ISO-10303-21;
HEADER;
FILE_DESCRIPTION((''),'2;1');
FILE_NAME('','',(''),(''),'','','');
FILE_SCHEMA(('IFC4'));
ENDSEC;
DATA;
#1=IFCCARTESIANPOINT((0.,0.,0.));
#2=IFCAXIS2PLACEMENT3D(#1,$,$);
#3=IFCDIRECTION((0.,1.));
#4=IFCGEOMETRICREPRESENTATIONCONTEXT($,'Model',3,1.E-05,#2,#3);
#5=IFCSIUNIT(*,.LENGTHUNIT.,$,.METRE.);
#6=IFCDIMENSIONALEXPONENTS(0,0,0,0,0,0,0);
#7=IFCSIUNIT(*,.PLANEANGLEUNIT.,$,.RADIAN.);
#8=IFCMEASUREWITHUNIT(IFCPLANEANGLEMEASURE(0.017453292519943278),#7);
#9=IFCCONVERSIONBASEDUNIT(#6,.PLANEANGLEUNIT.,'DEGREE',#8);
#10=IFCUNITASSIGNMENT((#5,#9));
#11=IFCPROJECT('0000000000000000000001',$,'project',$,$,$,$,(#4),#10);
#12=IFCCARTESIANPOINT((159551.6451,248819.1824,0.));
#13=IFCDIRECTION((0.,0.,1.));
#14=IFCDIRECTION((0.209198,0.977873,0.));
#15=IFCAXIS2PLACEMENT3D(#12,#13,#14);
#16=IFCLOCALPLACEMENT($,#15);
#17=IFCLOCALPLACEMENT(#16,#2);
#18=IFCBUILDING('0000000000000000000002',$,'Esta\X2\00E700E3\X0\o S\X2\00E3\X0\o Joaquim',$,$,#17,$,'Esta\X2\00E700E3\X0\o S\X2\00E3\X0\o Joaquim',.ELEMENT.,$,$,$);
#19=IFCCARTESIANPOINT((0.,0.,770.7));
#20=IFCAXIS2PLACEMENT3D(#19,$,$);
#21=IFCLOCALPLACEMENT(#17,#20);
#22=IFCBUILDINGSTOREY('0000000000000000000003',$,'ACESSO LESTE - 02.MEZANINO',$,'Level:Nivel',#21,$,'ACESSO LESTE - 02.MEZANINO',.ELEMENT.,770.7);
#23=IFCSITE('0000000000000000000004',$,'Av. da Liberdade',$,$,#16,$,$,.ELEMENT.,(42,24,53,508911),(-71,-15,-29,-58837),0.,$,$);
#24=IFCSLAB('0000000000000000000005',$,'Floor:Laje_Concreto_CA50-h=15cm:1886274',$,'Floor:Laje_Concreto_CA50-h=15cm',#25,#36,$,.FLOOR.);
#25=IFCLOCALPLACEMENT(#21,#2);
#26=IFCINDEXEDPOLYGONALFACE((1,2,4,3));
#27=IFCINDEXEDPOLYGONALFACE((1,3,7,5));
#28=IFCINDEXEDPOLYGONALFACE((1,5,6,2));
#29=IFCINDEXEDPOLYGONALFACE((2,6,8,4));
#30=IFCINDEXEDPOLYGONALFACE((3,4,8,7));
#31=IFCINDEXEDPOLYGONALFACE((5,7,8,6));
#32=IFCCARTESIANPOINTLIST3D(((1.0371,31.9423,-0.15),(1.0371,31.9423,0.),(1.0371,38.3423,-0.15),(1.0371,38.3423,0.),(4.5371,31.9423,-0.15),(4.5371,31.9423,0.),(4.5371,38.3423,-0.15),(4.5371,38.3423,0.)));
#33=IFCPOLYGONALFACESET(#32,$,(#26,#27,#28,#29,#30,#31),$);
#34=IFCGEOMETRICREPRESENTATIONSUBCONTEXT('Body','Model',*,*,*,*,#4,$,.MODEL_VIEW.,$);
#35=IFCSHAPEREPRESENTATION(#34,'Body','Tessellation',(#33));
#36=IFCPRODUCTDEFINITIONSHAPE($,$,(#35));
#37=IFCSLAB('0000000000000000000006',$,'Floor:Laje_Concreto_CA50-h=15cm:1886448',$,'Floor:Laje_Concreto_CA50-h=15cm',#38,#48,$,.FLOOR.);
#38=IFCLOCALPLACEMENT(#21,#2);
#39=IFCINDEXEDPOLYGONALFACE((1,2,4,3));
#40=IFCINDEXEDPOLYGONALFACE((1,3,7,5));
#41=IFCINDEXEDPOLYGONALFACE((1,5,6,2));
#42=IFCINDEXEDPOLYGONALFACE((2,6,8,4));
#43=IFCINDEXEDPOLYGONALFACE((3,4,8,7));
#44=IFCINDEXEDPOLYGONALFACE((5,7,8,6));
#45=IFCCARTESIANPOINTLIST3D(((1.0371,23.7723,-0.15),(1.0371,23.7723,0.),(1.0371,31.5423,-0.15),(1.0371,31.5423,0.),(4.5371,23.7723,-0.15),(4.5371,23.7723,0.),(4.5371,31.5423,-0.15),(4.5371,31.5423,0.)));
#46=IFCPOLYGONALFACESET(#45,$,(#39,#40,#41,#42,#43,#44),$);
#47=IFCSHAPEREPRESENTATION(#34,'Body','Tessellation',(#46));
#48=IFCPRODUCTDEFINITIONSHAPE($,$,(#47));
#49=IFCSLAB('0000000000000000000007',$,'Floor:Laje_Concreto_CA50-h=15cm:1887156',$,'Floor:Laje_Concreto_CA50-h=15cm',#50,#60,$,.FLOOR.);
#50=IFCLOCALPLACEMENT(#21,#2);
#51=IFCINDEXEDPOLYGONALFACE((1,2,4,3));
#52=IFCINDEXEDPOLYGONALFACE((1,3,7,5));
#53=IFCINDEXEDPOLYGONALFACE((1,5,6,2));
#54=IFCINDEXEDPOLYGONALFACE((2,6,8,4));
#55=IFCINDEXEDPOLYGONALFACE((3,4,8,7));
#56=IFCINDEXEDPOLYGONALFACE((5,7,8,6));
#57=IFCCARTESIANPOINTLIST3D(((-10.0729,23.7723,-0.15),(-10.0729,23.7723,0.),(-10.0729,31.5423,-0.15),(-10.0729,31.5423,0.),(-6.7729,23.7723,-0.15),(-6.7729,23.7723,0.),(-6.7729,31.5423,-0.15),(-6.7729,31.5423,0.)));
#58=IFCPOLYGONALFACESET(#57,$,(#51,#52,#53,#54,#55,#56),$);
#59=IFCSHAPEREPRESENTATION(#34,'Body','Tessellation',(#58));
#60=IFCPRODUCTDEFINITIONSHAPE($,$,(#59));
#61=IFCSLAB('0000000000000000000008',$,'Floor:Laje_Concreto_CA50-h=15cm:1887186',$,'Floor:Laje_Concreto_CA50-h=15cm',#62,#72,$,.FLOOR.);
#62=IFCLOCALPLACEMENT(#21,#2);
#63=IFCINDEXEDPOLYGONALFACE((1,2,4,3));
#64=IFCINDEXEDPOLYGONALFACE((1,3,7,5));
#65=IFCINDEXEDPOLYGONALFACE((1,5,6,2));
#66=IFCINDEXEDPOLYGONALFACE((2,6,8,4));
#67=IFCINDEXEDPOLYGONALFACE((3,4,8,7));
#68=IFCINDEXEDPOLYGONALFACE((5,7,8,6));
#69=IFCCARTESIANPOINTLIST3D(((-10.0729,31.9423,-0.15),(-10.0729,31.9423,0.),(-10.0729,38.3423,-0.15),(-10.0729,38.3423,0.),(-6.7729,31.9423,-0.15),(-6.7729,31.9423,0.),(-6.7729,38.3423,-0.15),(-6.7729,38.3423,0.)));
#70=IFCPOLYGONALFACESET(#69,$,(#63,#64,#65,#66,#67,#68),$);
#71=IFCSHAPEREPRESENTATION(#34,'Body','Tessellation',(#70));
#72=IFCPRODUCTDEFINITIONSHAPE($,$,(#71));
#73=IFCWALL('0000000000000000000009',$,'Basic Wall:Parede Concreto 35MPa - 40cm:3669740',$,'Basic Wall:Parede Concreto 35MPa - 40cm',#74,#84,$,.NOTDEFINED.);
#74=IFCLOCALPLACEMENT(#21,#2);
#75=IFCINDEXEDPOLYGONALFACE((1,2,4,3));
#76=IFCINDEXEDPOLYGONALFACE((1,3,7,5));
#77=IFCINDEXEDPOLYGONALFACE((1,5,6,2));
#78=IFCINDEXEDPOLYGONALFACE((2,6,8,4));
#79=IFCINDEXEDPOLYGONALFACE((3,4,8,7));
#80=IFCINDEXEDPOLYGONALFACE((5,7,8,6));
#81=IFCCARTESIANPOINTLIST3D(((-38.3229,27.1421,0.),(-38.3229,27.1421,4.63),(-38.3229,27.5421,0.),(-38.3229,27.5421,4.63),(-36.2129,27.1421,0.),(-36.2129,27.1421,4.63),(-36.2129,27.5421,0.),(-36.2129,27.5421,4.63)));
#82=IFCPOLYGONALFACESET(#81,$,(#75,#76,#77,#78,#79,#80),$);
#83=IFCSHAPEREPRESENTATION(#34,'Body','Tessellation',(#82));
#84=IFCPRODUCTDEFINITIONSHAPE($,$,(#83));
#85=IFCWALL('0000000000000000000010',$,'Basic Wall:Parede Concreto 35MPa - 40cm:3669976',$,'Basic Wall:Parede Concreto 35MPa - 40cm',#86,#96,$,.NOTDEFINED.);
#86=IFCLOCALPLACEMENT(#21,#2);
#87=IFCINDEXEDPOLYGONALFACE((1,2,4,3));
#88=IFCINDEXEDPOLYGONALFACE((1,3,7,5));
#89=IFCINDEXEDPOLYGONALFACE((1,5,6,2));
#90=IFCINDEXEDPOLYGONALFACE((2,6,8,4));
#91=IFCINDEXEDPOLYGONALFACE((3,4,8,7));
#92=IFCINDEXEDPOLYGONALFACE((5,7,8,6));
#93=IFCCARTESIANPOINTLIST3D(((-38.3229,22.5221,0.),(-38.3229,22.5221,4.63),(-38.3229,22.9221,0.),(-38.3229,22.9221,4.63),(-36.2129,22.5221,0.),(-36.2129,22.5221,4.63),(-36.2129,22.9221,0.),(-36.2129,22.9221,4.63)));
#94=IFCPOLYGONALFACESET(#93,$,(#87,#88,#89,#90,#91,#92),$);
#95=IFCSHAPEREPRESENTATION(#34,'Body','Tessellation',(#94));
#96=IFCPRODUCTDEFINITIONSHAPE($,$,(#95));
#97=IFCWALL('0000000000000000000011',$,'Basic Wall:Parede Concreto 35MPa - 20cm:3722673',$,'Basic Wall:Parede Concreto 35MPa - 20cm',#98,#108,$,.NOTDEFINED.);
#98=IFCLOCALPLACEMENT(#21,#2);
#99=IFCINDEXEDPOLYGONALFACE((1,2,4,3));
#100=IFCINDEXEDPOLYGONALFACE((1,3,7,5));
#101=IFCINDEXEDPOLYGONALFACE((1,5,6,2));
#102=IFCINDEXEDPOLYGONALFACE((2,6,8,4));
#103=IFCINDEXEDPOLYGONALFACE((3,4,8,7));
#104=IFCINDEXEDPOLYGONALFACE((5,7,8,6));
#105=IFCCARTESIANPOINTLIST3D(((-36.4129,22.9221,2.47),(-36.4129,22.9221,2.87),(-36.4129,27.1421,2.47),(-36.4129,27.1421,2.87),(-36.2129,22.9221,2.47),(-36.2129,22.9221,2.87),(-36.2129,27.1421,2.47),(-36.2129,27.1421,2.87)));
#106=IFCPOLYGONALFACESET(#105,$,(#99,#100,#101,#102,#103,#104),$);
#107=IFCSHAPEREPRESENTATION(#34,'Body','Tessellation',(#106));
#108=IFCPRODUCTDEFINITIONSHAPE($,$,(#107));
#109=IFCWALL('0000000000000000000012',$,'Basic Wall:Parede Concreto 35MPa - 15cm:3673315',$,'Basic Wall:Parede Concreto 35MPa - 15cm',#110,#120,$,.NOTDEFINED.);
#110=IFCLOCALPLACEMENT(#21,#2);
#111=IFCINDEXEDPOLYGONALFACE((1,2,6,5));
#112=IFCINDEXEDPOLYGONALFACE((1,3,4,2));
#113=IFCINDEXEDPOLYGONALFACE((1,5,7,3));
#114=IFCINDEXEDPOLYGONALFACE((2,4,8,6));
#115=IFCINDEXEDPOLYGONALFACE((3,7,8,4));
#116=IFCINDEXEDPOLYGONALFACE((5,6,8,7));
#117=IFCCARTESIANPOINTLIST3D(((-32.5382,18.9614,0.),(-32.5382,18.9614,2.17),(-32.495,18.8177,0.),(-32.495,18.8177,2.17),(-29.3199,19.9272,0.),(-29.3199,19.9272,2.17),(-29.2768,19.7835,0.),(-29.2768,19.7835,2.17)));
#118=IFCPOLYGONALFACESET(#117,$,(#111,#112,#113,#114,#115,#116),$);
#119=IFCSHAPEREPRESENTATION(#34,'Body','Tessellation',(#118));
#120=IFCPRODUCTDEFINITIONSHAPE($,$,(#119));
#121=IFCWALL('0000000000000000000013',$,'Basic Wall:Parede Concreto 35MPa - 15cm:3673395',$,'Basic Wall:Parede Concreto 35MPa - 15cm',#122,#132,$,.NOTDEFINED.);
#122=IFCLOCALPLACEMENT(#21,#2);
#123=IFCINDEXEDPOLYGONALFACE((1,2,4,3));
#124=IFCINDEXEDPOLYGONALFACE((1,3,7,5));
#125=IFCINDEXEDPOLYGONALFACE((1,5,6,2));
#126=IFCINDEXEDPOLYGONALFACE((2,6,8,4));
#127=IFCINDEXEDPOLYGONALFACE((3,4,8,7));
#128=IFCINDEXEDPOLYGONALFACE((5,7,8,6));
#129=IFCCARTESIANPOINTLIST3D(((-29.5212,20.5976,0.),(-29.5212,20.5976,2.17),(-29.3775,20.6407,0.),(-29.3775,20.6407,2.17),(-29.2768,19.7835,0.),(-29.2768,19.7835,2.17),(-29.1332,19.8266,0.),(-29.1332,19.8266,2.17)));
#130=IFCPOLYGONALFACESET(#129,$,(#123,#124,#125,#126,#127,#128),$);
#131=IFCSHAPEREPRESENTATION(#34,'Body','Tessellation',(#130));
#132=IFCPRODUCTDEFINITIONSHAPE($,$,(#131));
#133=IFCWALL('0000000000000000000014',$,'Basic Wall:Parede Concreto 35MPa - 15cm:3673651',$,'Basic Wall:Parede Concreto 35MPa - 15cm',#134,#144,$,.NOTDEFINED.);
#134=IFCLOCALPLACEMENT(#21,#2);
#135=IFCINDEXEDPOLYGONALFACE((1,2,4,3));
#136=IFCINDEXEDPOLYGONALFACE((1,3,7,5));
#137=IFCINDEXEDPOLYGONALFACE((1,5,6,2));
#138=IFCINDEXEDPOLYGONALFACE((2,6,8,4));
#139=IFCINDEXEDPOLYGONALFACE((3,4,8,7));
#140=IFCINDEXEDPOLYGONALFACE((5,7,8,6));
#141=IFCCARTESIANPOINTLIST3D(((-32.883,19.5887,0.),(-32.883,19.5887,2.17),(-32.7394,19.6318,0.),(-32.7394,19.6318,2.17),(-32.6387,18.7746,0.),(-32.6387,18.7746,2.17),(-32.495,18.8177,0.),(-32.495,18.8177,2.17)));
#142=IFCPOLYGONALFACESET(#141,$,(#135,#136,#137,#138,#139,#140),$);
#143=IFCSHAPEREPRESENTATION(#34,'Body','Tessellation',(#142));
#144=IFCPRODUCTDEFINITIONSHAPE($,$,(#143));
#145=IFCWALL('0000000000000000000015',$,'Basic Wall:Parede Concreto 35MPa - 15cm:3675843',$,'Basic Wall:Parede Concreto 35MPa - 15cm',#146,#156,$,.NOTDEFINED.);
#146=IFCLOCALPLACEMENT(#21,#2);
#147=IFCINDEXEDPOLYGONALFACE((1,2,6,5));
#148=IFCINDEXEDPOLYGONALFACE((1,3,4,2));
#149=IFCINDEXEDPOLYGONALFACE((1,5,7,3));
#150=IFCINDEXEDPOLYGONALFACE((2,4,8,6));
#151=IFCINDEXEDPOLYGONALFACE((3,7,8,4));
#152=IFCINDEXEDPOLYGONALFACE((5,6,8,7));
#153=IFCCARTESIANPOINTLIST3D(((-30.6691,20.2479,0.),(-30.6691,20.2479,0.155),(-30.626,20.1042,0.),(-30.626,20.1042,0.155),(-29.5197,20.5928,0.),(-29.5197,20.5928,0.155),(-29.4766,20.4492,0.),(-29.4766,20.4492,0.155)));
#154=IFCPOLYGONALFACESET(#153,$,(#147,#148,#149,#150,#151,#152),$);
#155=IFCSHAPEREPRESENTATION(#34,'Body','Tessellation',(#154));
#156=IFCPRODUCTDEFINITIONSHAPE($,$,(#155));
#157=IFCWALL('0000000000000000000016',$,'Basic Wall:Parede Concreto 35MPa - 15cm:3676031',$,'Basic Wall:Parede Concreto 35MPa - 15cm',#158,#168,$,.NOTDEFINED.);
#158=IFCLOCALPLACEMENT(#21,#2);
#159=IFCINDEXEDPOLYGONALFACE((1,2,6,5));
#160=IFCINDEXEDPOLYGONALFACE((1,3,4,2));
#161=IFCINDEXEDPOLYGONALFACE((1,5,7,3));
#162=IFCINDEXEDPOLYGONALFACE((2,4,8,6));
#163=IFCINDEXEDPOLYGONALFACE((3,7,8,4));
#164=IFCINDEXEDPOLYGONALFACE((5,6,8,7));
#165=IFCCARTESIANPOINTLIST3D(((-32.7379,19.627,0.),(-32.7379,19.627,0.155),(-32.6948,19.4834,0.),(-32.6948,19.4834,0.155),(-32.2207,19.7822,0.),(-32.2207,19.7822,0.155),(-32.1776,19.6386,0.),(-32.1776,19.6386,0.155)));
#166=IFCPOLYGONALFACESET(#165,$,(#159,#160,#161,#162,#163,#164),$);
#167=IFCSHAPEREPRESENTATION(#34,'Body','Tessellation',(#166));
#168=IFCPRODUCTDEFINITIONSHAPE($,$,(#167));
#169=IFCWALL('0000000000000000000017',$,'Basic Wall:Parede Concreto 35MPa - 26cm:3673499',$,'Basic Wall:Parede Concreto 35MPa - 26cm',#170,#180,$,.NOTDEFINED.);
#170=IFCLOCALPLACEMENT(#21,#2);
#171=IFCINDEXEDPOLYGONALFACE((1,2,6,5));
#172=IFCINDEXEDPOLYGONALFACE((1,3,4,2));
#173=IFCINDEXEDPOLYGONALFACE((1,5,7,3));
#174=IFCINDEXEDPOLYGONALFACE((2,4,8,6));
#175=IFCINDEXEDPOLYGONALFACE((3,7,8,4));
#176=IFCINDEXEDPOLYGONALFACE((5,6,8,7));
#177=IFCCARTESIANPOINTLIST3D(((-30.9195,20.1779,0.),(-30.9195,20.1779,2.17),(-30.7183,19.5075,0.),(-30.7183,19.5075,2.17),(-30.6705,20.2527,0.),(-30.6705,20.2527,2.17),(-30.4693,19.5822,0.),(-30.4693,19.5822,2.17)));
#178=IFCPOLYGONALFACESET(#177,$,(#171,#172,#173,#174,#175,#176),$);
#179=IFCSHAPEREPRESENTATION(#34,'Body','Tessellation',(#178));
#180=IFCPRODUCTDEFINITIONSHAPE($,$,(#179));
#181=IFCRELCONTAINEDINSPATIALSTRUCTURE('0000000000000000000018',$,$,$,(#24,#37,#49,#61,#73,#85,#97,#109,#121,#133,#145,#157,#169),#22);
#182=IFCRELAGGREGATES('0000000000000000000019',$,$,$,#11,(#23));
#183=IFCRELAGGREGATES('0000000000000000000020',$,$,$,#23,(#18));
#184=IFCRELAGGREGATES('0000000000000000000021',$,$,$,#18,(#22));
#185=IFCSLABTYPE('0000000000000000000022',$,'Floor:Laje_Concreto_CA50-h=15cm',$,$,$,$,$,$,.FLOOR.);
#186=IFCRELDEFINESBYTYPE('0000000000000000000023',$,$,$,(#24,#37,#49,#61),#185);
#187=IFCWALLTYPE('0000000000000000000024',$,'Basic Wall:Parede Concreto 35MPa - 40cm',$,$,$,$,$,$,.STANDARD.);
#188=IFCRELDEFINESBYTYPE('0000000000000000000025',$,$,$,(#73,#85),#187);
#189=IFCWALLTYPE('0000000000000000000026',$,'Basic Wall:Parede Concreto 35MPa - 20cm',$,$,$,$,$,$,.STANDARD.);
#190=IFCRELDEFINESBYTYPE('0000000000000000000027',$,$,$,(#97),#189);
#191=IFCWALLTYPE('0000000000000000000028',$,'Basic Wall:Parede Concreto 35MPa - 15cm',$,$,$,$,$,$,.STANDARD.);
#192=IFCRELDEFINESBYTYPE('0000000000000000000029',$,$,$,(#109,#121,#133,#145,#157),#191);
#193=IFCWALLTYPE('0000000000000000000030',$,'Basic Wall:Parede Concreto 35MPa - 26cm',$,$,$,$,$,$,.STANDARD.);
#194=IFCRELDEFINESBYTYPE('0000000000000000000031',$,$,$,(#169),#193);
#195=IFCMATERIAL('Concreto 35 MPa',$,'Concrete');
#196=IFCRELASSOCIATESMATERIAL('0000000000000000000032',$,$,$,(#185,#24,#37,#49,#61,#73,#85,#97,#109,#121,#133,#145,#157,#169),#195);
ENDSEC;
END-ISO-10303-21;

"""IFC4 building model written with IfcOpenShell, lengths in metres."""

from ifc_helpers import new_model, entity, si_unit, converted_unit, direction, frame, origin, place, context, subcontext, project, spatial, indexed_curve, outline, extrude, material, type_object, element, save


model = new_model("IFC4")

# Units and contexts
model_context = context("Model", 3, precision=1e-05, world=origin(), true_north=direction((0.0, 1.0)))
body_context = subcontext(model_context, "Body", "Model", "MODEL_VIEW")
ifc_project = project(units=[si_unit("LENGTHUNIT", "METRE"), converted_unit("PLANEANGLEUNIT", "DEGREE", entity("IfcPlaneAngleMeasure", 0.017453292519943278), si_unit("PLANEANGLEUNIT", "RADIAN"), dimensions=[0, 0, 0, 0, 0, 0, 0])], contexts=[model_context])

# Site, building, storey
site_placement = place(None, frame((159551.6451, 248819.1824, 0.0), z_axis=(0.0, 0.0, 1.0), x_axis=(0.209198, 0.977873, 0.0)))
site = spatial("IfcSite", under=ifc_project, at=site_placement, Name="Av. da Liberdade", CompositionType="ELEMENT", RefLatitude=(42, 24, 53, 508911), RefLongitude=(-71, -15, -29, -58837), RefElevation=0.0)
building_placement = place(site_placement, origin())
building = spatial("IfcBuilding", under=site, at=building_placement, Name="Estação São Joaquim", LongName="Estação São Joaquim", CompositionType="ELEMENT")
storey_placement = place(building_placement, frame((0.0, 0.0, 770.7)))
storey = spatial("IfcBuildingStorey", under=building, at=storey_placement, Name="ACESSO LESTE - 02.MEZANINO", ObjectType="Level:Nivel", LongName="ACESSO LESTE - 02.MEZANINO", CompositionType="ELEMENT", Elevation=770.7)

# Slabs
ifc_material = material(Name="Concreto 35 MPa", Category="Concrete")
slab_type_1 = type_object("IfcSlabType", Name="Floor:Laje_Concreto_CA50-h=15cm", PredefinedType="FLOOR", material=ifc_material)
slab_1_placement = place(storey_placement, origin())
element("IfcSlab", 1, at=slab_1_placement, inside=storey, type_object=slab_type_1, material=ifc_material, Name="Floor:Laje_Concreto_CA50-h=15cm:1886274", ObjectType="Floor:Laje_Concreto_CA50-h=15cm", PredefinedType="FLOOR", context=body_context, shape_type="SweptSolid", body=[
    extrude(outline(indexed_curve([(-3.2, -1.75), (3.2, -1.75), (3.2, 1.75), (-3.2, 1.75), (-3.2, -1.75)], self_intersect=False)), frame((2.7871, 35.1423, 0.0), z_axis=(0.0, 0.0, -1.0), x_axis=(0.0, -1.0, 0.0)), (0.0, 0.0, 1.0), 0.15),
])
slab_2_placement = place(storey_placement, origin())
element("IfcSlab", 2, at=slab_2_placement, inside=storey, type_object=slab_type_1, material=ifc_material, Name="Floor:Laje_Concreto_CA50-h=15cm:1886448", ObjectType="Floor:Laje_Concreto_CA50-h=15cm", PredefinedType="FLOOR", context=body_context, shape_type="SweptSolid", body=[
    extrude(outline(indexed_curve([(-3.885, -1.75), (3.885, -1.75), (3.885, 1.75), (-3.885, 1.75), (-3.885, -1.75)], self_intersect=False)), frame((2.7871, 27.6573, 0.0), z_axis=(0.0, 0.0, -1.0), x_axis=(0.0, -1.0, 0.0)), (0.0, 0.0, 1.0), 0.15),
])
slab_3_placement = place(storey_placement, origin())
element("IfcSlab", 3, at=slab_3_placement, inside=storey, type_object=slab_type_1, material=ifc_material, Name="Floor:Laje_Concreto_CA50-h=15cm:1887156", ObjectType="Floor:Laje_Concreto_CA50-h=15cm", PredefinedType="FLOOR", context=body_context, shape_type="SweptSolid", body=[
    extrude(outline(indexed_curve([(-1.65, -3.885), (1.65, -3.885), (1.65, 3.885), (-1.65, 3.885), (-1.65, -3.885)], self_intersect=False)), frame((-8.4229, 27.6573, 0.0), z_axis=(0.0, 0.0, -1.0), x_axis=(1.0, 0.0, 0.0)), (0.0, 0.0, 1.0), 0.15),
])
slab_4_placement = place(storey_placement, origin())
element("IfcSlab", 4, at=slab_4_placement, inside=storey, type_object=slab_type_1, material=ifc_material, Name="Floor:Laje_Concreto_CA50-h=15cm:1887186", ObjectType="Floor:Laje_Concreto_CA50-h=15cm", PredefinedType="FLOOR", context=body_context, shape_type="SweptSolid", body=[
    extrude(outline(indexed_curve([(-1.65, -3.2), (1.65, -3.2), (1.65, 3.2), (-1.65, 3.2), (-1.65, -3.2)], self_intersect=False)), frame((-8.4229, 35.1423, 0.0), z_axis=(0.0, 0.0, -1.0), x_axis=(1.0, 0.0, 0.0)), (0.0, 0.0, 1.0), 0.15),
])

# Walls
wall_type_1 = type_object("IfcWallType", Name="Basic Wall:Parede Concreto 35MPa - 40cm", PredefinedType="STANDARD")
wall_1_placement = place(storey_placement, frame((-36.2129, 27.3421, 0.0), z_axis=(0.0, 0.0, 1.0), x_axis=(-1.0, 0.0, 0.0)))
element("IfcWall", 5, at=wall_1_placement, inside=storey, type_object=wall_type_1, material=ifc_material, Name="Basic Wall:Parede Concreto 35MPa - 40cm:3669740", ObjectType="Basic Wall:Parede Concreto 35MPa - 40cm", PredefinedType="NOTDEFINED", context=body_context, shape_type="SweptSolid", body=[
    extrude(outline(indexed_curve([(2.11, 0.2), (0.0, 0.2), (0.0, -0.2), (2.11, -0.2), (2.11, 0.2)], self_intersect=False)), origin(), (0.0, 0.0, 1.0), 4.63),
])
wall_2_placement = place(storey_placement, frame((-38.3229, 22.7221, 0.0)))
element("IfcWall", 6, at=wall_2_placement, inside=storey, type_object=wall_type_1, material=ifc_material, Name="Basic Wall:Parede Concreto 35MPa - 40cm:3669976", ObjectType="Basic Wall:Parede Concreto 35MPa - 40cm", PredefinedType="NOTDEFINED", context=body_context, shape_type="SweptSolid", body=[
    extrude(outline(indexed_curve([(2.11, 0.2), (0.0, 0.2), (0.0, -0.2), (2.11, -0.2), (2.11, 0.2)], self_intersect=False)), origin(), (0.0, 0.0, 1.0), 4.63),
])
wall_type_2 = type_object("IfcWallType", Name="Basic Wall:Parede Concreto 35MPa - 20cm", PredefinedType="STANDARD")
wall_3_placement = place(storey_placement, frame((-36.3129, 27.1421, 2.47), z_axis=(0.0, 0.0, 1.0), x_axis=(0.0, -1.0, 0.0)))
element("IfcWall", 7, at=wall_3_placement, inside=storey, type_object=wall_type_2, material=ifc_material, Name="Basic Wall:Parede Concreto 35MPa - 20cm:3722673", ObjectType="Basic Wall:Parede Concreto 35MPa - 20cm", PredefinedType="NOTDEFINED", context=body_context, shape_type="SweptSolid", body=[
    extrude(outline(indexed_curve([(4.2201, 0.1), (0.0, 0.1), (0.0, -0.1), (4.2201, -0.1), (4.2201, 0.1)], self_intersect=False)), origin(), (0.0, 0.0, 1.0), 0.4),
])
wall_type_3 = type_object("IfcWallType", Name="Basic Wall:Parede Concreto 35MPa - 15cm", PredefinedType="STANDARD")
wall_4_placement = place(storey_placement, frame((-32.5166, 18.8895, 0.0), z_axis=(0.0, 0.0, 1.0), x_axis=(0.957798, 0.287441, 0.0)))
element("IfcWall", 8, at=wall_4_placement, inside=storey, type_object=wall_type_3, material=ifc_material, Name="Basic Wall:Parede Concreto 35MPa - 15cm:3673315", ObjectType="Basic Wall:Parede Concreto 35MPa - 15cm", PredefinedType="NOTDEFINED", context=body_context, shape_type="SweptSolid", body=[
    extrude(outline(indexed_curve([(3.36, 0.075), (0.0, 0.075), (0.0, -0.075), (3.36, -0.075), (3.36, 0.075)], self_intersect=False)), origin(), (0.0, 0.0, 1.0), 2.17),
])
wall_5_placement = place(storey_placement, frame((-29.205, 19.805, 0.0), z_axis=(0.0, 0.0, 1.0), x_axis=(-0.287441, 0.957798, 0.0)))
element("IfcWall", 9, at=wall_5_placement, inside=storey, type_object=wall_type_3, material=ifc_material, Name="Basic Wall:Parede Concreto 35MPa - 15cm:3673395", ObjectType="Basic Wall:Parede Concreto 35MPa - 15cm", PredefinedType="NOTDEFINED", context=body_context, shape_type="SweptSolid", body=[
    extrude(outline(indexed_curve([(0.85, 0.075), (0.0, 0.075), (0.0, -0.075), (0.85, -0.075), (0.85, 0.075)], self_intersect=False)), origin(), (0.0, 0.0, 1.0), 2.17),
])
wall_6_placement = place(storey_placement, frame((-32.5669, 18.7961, 0.0), z_axis=(0.0, 0.0, 1.0), x_axis=(-0.287441, 0.957798, 0.0)))
element("IfcWall", 10, at=wall_6_placement, inside=storey, type_object=wall_type_3, material=ifc_material, Name="Basic Wall:Parede Concreto 35MPa - 15cm:3673651", ObjectType="Basic Wall:Parede Concreto 35MPa - 15cm", PredefinedType="NOTDEFINED", context=body_context, shape_type="SweptSolid", body=[
    extrude(outline(indexed_curve([(0.85, 0.075), (0.0, 0.075), (0.0, -0.075), (0.85, -0.075), (0.85, 0.075)], self_intersect=False)), origin(), (0.0, 0.0, 1.0), 2.17),
])
wall_7_placement = place(storey_placement, frame((-30.6475, 20.1761, 0.0), z_axis=(0.0, 0.0, 1.0), x_axis=(0.957798, 0.287441, 0.0)))
element("IfcWall", 11, at=wall_7_placement, inside=storey, type_object=wall_type_3, material=ifc_material, Name="Basic Wall:Parede Concreto 35MPa - 15cm:3675843", ObjectType="Basic Wall:Parede Concreto 35MPa - 15cm", PredefinedType="NOTDEFINED", context=body_context, shape_type="SweptSolid", body=[
    extrude(outline(indexed_curve([(1.2, 0.075), (0.0, 0.075), (0.0, -0.075), (1.2, -0.075), (1.2, 0.075)], self_intersect=False)), origin(), (0.0, 0.0, 1.0), 0.155),
])
wall_8_placement = place(storey_placement, frame((-32.7164, 19.5552, 0.0), z_axis=(0.0, 0.0, 1.0), x_axis=(0.957798, 0.287441, 0.0)))
element("IfcWall", 12, at=wall_8_placement, inside=storey, type_object=wall_type_3, material=ifc_material, Name="Basic Wall:Parede Concreto 35MPa - 15cm:3676031", ObjectType="Basic Wall:Parede Concreto 35MPa - 15cm", PredefinedType="NOTDEFINED", context=body_context, shape_type="SweptSolid", body=[
    extrude(outline(indexed_curve([(0.54, 0.075), (0.0, 0.075), (0.0, -0.075), (0.54, -0.075), (0.54, 0.075)], self_intersect=False)), origin(), (0.0, 0.0, 1.0), 0.155),
])
wall_type_4 = type_object("IfcWallType", Name="Basic Wall:Parede Concreto 35MPa - 26cm", PredefinedType="STANDARD")
wall_9_placement = place(storey_placement, frame((-30.5938, 19.5449, 0.0), z_axis=(0.0, 0.0, 1.0), x_axis=(-0.287441, 0.957798, 0.0)))
element("IfcWall", 13, at=wall_9_placement, inside=storey, type_object=wall_type_4, material=ifc_material, Name="Basic Wall:Parede Concreto 35MPa - 26cm:3673499", ObjectType="Basic Wall:Parede Concreto 35MPa - 26cm", PredefinedType="NOTDEFINED", context=body_context, shape_type="SweptSolid", body=[
    extrude(outline(indexed_curve([(0.7, 0.13), (0.0, 0.13), (0.0, -0.13), (0.7, -0.13), (0.7, 0.13)], self_intersect=False)), origin(), (0.0, 0.0, 1.0), 2.17),
])

save(model, "model.ifc")
